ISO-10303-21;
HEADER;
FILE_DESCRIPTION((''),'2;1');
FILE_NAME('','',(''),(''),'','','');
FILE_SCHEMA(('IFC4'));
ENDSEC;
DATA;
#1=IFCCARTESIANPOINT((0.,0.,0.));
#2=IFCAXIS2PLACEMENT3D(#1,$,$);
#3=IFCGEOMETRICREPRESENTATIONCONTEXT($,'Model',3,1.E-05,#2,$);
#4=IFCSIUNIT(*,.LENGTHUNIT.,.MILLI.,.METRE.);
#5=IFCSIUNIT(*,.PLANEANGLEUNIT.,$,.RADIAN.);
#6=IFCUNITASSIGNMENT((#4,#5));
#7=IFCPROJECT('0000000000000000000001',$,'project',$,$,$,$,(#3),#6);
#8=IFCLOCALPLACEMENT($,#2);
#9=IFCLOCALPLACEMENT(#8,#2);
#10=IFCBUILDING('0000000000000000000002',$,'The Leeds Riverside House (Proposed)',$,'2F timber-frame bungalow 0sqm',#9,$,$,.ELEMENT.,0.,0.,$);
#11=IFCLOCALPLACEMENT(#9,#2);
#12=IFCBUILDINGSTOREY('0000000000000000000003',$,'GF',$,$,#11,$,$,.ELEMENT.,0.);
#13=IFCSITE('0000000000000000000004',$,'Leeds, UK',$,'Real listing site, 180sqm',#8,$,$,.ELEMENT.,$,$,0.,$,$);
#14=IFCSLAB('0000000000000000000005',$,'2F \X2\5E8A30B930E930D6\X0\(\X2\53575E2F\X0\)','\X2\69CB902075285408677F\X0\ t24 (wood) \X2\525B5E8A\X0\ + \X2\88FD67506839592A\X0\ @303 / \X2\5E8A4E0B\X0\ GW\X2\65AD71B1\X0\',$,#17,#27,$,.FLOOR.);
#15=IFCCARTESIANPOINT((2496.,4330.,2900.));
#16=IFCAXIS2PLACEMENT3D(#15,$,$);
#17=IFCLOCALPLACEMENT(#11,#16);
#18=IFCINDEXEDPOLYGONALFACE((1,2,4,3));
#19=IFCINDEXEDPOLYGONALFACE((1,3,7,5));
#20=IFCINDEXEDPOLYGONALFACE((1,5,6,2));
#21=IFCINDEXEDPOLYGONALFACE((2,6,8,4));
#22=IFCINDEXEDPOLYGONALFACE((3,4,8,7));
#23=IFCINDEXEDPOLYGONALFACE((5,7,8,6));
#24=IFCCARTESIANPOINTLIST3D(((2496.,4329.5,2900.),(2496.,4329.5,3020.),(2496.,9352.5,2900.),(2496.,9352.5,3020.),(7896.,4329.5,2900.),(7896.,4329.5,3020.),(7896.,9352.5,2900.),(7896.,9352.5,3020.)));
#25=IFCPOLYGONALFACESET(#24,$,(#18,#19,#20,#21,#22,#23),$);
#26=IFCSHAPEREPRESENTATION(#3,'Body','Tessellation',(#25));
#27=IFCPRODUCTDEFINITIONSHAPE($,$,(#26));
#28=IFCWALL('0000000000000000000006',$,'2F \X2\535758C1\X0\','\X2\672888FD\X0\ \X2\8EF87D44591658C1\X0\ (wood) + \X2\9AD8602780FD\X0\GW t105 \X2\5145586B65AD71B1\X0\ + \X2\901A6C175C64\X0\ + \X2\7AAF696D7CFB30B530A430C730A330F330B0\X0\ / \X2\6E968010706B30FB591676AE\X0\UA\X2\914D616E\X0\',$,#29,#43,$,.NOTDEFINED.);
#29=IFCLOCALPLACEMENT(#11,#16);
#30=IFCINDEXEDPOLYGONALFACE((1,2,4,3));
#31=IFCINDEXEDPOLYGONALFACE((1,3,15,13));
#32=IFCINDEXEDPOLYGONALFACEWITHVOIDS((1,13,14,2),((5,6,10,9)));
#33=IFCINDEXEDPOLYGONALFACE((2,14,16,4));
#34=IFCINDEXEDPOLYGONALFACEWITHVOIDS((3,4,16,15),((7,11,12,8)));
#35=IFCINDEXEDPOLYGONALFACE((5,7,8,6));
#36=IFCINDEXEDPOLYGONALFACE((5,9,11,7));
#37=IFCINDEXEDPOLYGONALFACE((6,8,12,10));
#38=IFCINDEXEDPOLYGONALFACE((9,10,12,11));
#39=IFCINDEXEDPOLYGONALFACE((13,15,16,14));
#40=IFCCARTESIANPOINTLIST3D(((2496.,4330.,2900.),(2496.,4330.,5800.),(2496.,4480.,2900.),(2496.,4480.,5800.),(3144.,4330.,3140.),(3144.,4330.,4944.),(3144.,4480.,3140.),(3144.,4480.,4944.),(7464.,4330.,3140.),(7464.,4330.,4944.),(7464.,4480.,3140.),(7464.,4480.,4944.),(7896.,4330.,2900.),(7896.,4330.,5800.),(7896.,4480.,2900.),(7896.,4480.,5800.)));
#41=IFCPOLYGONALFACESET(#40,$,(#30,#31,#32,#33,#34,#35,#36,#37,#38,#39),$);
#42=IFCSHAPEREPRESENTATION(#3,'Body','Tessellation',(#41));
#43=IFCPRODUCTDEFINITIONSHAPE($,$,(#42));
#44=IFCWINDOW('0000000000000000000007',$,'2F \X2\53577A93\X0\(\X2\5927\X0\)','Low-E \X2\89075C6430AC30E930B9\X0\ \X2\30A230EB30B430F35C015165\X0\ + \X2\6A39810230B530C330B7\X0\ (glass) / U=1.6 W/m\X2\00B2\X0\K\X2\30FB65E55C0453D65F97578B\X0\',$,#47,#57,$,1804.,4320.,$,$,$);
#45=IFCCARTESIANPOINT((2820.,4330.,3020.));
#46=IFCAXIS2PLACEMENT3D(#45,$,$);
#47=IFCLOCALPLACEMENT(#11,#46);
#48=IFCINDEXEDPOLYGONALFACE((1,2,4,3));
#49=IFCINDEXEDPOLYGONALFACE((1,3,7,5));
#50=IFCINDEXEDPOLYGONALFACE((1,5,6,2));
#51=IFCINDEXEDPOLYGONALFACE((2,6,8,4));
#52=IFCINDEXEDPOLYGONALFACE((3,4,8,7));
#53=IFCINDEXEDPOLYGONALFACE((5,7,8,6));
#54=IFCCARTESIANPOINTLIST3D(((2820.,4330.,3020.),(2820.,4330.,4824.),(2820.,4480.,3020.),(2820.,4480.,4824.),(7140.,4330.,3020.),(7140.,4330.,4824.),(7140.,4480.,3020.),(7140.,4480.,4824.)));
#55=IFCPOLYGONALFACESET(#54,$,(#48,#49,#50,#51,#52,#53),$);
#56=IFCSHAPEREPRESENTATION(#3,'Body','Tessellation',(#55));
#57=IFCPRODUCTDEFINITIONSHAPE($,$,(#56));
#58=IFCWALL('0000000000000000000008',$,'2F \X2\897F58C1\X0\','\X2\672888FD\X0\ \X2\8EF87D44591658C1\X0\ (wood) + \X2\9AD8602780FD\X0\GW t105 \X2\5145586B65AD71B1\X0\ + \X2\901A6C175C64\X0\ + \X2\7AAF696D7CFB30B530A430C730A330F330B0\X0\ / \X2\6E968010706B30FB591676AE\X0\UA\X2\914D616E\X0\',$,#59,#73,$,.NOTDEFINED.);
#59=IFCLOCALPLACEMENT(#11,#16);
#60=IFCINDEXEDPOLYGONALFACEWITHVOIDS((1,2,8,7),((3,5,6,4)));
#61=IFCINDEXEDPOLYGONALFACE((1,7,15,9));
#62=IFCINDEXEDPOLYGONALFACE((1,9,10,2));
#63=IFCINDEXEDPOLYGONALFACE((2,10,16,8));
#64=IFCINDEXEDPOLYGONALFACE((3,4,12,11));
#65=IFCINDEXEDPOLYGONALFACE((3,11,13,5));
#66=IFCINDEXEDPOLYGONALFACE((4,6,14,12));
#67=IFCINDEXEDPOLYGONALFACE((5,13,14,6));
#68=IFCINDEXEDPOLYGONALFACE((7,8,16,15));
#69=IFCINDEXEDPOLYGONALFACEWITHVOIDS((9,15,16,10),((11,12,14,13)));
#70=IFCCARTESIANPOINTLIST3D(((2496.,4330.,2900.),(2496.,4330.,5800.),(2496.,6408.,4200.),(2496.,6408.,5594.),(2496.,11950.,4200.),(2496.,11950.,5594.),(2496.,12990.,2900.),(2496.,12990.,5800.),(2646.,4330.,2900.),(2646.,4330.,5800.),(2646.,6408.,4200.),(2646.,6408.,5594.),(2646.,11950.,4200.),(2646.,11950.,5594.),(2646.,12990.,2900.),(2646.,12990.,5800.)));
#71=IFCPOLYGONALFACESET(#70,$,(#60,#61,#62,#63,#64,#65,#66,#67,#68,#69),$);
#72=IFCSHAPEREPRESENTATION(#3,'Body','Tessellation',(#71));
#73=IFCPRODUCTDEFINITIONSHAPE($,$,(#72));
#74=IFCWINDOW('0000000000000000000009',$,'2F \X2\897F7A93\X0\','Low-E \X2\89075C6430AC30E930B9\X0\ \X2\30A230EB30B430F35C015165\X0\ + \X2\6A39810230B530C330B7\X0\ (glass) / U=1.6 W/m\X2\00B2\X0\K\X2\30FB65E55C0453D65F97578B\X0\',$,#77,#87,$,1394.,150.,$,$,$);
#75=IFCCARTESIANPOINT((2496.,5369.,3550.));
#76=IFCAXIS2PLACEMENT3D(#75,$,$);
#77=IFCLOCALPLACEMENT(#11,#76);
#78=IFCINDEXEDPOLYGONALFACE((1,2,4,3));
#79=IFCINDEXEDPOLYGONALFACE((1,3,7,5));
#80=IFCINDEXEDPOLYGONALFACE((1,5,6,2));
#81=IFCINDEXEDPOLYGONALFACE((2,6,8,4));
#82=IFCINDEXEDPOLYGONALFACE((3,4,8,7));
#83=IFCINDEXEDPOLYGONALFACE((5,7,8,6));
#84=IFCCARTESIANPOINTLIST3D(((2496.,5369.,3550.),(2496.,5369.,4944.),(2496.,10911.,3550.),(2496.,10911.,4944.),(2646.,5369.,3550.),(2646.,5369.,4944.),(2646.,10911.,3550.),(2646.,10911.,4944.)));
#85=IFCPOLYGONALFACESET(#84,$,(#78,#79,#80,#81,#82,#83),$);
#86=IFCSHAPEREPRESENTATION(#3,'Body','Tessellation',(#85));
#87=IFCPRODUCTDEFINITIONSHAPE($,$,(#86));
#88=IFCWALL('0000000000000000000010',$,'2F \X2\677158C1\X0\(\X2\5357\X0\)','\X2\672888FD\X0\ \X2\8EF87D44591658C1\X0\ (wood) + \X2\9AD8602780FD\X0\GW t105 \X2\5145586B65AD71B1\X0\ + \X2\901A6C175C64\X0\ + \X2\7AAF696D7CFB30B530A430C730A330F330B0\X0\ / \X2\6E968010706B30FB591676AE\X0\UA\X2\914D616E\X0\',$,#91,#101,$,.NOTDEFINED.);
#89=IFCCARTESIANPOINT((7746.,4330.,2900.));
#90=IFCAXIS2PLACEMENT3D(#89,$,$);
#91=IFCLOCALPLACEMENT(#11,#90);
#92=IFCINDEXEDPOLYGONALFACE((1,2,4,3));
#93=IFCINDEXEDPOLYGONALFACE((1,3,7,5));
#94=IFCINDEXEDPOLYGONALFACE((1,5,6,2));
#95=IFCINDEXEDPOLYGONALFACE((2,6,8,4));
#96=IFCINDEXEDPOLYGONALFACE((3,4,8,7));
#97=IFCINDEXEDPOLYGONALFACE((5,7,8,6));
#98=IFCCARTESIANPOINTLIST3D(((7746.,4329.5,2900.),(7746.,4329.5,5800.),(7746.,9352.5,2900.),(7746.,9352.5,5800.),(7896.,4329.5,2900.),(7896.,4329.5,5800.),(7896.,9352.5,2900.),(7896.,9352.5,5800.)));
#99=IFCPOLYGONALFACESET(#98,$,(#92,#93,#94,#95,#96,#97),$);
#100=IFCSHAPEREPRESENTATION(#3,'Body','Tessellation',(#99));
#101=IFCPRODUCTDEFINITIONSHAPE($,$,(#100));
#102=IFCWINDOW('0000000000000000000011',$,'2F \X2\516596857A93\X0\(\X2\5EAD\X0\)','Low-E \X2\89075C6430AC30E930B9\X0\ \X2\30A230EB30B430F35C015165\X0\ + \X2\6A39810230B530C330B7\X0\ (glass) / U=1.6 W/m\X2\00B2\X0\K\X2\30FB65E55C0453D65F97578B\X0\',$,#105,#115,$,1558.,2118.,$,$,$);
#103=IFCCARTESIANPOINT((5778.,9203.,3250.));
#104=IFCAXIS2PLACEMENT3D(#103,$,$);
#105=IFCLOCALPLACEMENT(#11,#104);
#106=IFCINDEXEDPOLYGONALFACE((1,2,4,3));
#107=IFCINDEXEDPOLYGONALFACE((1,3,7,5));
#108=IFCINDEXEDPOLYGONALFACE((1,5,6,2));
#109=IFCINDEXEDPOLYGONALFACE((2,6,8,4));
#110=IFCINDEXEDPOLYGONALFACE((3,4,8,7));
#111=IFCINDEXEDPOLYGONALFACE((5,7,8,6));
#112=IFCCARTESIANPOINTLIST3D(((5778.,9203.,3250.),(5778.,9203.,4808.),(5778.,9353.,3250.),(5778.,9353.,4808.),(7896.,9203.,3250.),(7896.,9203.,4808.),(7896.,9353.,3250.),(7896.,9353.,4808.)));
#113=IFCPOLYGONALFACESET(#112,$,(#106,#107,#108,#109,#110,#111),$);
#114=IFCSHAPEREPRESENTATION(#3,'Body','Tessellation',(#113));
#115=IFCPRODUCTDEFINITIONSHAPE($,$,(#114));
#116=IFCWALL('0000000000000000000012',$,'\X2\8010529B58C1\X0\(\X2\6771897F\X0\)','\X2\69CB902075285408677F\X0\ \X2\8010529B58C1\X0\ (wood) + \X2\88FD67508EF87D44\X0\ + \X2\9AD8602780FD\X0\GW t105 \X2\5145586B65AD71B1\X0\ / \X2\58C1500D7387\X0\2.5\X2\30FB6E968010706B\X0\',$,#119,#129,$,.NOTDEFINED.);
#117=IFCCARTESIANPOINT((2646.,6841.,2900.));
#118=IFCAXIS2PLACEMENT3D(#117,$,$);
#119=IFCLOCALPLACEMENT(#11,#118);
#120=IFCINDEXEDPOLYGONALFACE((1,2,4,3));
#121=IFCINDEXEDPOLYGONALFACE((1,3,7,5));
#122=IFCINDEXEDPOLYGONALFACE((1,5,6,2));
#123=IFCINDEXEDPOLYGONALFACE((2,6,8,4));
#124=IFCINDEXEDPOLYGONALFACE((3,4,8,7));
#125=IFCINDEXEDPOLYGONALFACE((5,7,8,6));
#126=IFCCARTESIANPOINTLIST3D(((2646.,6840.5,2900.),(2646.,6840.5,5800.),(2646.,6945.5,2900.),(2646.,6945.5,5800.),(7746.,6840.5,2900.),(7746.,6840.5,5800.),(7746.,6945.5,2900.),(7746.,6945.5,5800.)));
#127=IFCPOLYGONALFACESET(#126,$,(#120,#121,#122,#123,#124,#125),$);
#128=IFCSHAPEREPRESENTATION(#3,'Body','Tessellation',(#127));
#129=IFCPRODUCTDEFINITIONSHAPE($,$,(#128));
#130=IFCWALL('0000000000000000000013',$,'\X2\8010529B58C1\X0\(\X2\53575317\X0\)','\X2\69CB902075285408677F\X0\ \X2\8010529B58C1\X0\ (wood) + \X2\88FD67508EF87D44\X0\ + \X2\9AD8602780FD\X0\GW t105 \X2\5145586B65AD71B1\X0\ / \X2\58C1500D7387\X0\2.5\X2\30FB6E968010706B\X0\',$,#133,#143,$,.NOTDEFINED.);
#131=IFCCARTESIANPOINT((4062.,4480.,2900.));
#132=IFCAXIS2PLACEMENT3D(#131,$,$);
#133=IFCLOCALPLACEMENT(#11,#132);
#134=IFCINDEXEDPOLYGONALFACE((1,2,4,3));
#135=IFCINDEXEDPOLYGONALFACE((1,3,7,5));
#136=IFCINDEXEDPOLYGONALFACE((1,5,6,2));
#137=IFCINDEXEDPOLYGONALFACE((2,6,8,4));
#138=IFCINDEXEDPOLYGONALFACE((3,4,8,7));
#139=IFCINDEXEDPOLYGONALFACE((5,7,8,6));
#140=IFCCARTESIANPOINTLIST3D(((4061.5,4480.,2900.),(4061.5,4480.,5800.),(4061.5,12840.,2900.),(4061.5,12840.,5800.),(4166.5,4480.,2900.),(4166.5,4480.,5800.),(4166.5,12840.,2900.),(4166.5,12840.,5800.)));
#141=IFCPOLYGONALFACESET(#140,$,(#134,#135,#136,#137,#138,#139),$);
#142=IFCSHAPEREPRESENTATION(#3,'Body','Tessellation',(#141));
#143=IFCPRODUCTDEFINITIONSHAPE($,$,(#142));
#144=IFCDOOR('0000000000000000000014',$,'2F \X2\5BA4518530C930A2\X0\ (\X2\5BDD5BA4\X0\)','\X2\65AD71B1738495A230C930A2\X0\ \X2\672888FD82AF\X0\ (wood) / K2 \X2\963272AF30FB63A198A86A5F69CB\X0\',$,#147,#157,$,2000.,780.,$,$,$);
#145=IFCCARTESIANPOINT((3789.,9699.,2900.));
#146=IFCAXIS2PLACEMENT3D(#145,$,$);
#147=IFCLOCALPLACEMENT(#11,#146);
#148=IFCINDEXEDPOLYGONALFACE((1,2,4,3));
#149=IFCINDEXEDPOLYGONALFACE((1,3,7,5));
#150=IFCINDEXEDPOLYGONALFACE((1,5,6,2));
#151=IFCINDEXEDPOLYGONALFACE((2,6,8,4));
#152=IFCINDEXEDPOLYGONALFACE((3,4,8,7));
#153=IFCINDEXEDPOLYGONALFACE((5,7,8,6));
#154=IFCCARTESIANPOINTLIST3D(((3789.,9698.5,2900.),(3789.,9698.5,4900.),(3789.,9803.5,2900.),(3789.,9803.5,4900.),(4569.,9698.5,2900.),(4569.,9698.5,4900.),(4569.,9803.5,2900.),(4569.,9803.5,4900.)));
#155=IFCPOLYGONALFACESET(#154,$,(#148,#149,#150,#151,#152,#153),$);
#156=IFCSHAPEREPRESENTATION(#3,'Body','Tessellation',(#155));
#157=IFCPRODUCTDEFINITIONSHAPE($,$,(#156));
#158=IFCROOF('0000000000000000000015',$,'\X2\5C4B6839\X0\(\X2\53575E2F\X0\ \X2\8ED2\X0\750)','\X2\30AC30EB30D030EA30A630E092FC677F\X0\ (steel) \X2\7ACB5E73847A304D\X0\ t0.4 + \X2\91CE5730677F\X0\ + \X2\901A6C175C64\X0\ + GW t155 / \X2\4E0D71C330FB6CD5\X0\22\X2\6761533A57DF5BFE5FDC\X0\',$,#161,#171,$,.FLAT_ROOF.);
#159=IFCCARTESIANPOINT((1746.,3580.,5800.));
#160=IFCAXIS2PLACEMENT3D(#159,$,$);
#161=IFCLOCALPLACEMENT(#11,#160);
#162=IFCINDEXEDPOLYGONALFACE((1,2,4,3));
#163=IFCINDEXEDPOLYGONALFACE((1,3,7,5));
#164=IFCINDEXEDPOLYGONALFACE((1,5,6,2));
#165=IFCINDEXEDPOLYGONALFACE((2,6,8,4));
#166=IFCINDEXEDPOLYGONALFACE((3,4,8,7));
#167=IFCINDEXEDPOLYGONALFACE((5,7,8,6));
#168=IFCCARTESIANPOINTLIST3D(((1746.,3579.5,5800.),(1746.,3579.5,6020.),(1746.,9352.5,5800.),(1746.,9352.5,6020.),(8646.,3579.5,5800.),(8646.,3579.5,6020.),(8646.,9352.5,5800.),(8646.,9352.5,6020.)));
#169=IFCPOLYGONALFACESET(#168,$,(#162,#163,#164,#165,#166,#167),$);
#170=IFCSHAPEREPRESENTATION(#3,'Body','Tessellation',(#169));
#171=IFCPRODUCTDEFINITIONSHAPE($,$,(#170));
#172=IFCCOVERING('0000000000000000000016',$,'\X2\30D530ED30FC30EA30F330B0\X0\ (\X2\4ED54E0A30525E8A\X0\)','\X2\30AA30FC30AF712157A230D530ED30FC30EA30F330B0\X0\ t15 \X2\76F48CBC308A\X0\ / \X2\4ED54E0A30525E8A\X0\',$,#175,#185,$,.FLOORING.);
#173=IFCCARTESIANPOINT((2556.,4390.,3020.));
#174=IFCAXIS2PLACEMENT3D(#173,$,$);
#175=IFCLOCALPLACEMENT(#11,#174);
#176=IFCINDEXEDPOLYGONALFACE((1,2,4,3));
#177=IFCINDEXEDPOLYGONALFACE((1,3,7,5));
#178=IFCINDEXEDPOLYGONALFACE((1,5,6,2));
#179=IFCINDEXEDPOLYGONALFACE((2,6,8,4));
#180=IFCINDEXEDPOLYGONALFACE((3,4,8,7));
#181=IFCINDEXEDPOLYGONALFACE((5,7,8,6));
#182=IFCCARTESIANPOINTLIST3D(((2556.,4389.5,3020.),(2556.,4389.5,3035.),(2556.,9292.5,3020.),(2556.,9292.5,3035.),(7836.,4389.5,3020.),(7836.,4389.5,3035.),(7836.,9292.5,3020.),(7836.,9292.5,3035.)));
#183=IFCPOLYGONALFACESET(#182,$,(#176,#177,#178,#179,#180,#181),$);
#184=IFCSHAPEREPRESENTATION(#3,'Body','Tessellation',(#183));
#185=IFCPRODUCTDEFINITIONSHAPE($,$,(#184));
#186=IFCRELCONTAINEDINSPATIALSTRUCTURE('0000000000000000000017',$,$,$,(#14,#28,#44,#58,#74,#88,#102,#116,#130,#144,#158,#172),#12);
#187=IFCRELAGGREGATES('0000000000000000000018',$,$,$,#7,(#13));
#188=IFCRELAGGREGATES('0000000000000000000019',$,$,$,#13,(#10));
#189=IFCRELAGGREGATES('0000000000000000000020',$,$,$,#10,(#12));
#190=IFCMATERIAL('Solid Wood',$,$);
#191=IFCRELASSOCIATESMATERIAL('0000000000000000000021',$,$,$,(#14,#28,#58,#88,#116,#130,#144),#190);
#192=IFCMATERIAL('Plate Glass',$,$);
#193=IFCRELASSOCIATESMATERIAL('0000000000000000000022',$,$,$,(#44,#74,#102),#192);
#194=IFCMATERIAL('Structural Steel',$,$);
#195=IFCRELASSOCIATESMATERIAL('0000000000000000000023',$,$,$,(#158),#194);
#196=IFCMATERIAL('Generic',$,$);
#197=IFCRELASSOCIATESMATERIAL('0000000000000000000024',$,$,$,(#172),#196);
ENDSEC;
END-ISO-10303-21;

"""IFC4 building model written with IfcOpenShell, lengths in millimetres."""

from ifc_helpers import new_model, si_unit, frame, frame_2d, origin, place, context, project, spatial, rectangle, extrude, material, element, fill, save


model = new_model("IFC4")

# Units and contexts
model_context = context("Model", 3, precision=1e-05, world=origin())
ifc_project = project(units=[si_unit("LENGTHUNIT", "METRE", prefix="MILLI"), si_unit("PLANEANGLEUNIT", "RADIAN")], contexts=[model_context])

# Site, building, storey
site_placement = place(None, origin())
site = spatial("IfcSite", under=ifc_project, at=site_placement, Name="Leeds, UK", ObjectType="Real listing site, 180sqm", CompositionType="ELEMENT", RefElevation=0.0)
building_placement = place(site_placement, origin())
building = spatial("IfcBuilding", under=site, at=building_placement, Name="The Leeds Riverside House (Proposed)", ObjectType="2F timber-frame bungalow 0sqm", CompositionType="ELEMENT", ElevationOfRefHeight=0.0, ElevationOfTerrain=0.0)
storey_placement = place(building_placement, origin())
storey = spatial("IfcBuildingStorey", under=building, at=storey_placement, Name="GF", CompositionType="ELEMENT", Elevation=0.0)

# Slab
ifc_material_1 = material(Name="Solid Wood")
slab_placement = place(storey_placement, frame((2496.0, 4330.0, 2900.0)))
element("IfcSlab", 1, at=slab_placement, inside=storey, material=ifc_material_1, Name="2F 床スラブ(南帯)", Description="構造用合板 t24 (wood) 剛床 + 製材根太 @303 / 床下 GW断熱", PredefinedType="FLOOR", context=model_context, shape_type="SweptSolid", body=[
    extrude(rectangle(XDim=5400.0, YDim=5023.0, at=frame_2d((2700.0, 2511.0))), frame((2496.0, 4330.0, 2900.0)), (0.0, 0.0, 1.0), 120.0),
])

# Walls, openings, windows
wall_1_placement = place(storey_placement, frame((2496.0, 4330.0, 2900.0)))
wall_1 = element("IfcWall", 2, at=wall_1_placement, inside=storey, material=ifc_material_1, Name="2F 南壁", Description="木製 軸組外壁 (wood) + 高性能GW t105 充填断熱 + 通気層 + 窯業系サイディング / 準耐火・外皮UA配慮", PredefinedType="NOTDEFINED", context=model_context, shape_type="SweptSolid", body=[
    extrude(rectangle(XDim=5400.0, YDim=150.0, at=frame_2d((2700.0, 75.0))), frame((2496.0, 4330.0, 2900.0)), (0.0, 0.0, 1.0), 2900.0),
])
opening_1_placement = place(storey_placement, frame((2820.0, 4330.0, 3020.0)))
opening_1 = element("IfcOpeningElement", 3, at=opening_1_placement, cuts=wall_1, PredefinedType="NOTDEFINED", context=model_context, shape_type="SweptSolid", body=[
    extrude(rectangle(XDim=4320.0, YDim=150.0, at=frame_2d((2160.0, 75.0))), frame((2820.0, 4330.0, 3020.0)), (0.0, 0.0, 1.0), 1804.0),
])
ifc_material_2 = material(Name="Plate Glass")
window_1_placement = place(storey_placement, frame((2820.0, 4330.0, 3020.0)))
window_1 = element("IfcWindow", 4, at=window_1_placement, inside=storey, material=ifc_material_2, Name="2F 南窓(大)", Description="Low-E 複層ガラス アルゴン封入 + 樹脂サッシ (glass) / U=1.6 W/m²K・日射取得型", OverallHeight=1804.0, OverallWidth=4320.0, context=model_context, shape_type="SweptSolid", body=[
    extrude(rectangle(XDim=4320.0, YDim=150.0, at=frame_2d((2160.0, 75.0))), frame((2820.0, 4330.0, 3020.0)), (0.0, 0.0, 1.0), 1804.0),
])
fill(opening_1, window_1)
wall_2_placement = place(storey_placement, frame((2496.0, 4330.0, 2900.0)))
wall_2 = element("IfcWall", 5, at=wall_2_placement, inside=storey, material=ifc_material_1, Name="2F 西壁", Description="木製 軸組外壁 (wood) + 高性能GW t105 充填断熱 + 通気層 + 窯業系サイディング / 準耐火・外皮UA配慮", PredefinedType="NOTDEFINED", context=model_context, shape_type="SweptSolid", body=[
    extrude(rectangle(XDim=150.0, YDim=8660.0, at=frame_2d((75.0, 4330.0))), frame((2496.0, 4330.0, 2900.0)), (0.0, 0.0, 1.0), 2900.0),
])
opening_2_placement = place(storey_placement, frame((2496.0, 5369.0, 3550.0)))
opening_2 = element("IfcOpeningElement", 6, at=opening_2_placement, cuts=wall_2, PredefinedType="NOTDEFINED", context=model_context, shape_type="SweptSolid", body=[
    extrude(rectangle(XDim=150.0, YDim=5542.0, at=frame_2d((75.0, 2771.0))), frame((2496.0, 5369.0, 3550.0)), (0.0, 0.0, 1.0), 1394.0),
])
window_2_placement = place(storey_placement, frame((2496.0, 5369.0, 3550.0)))
window_2 = element("IfcWindow", 7, at=window_2_placement, inside=storey, material=ifc_material_2, Name="2F 西窓", Description="Low-E 複層ガラス アルゴン封入 + 樹脂サッシ (glass) / U=1.6 W/m²K・日射取得型", OverallHeight=1394.0, OverallWidth=150.0, context=model_context, shape_type="SweptSolid", body=[
    extrude(rectangle(XDim=150.0, YDim=5542.0, at=frame_2d((75.0, 2771.0))), frame((2496.0, 5369.0, 3550.0)), (0.0, 0.0, 1.0), 1394.0),
])
fill(opening_2, window_2)
wall_3_placement = place(storey_placement, frame((7746.0, 4330.0, 2900.0)))
wall_3 = element("IfcWall", 8, at=wall_3_placement, inside=storey, material=ifc_material_1, Name="2F 東壁(南)", Description="木製 軸組外壁 (wood) + 高性能GW t105 充填断熱 + 通気層 + 窯業系サイディング / 準耐火・外皮UA配慮", PredefinedType="NOTDEFINED", context=model_context, shape_type="SweptSolid", body=[
    extrude(rectangle(XDim=150.0, YDim=5023.0, at=frame_2d((75.0, 2511.0))), frame((7746.0, 4330.0, 2900.0)), (0.0, 0.0, 1.0), 2900.0),
])
opening_3_placement = place(storey_placement, frame((5778.0, 9203.0, 3250.0)))
opening_3 = element("IfcOpeningElement", 9, at=opening_3_placement, cuts=wall_3, PredefinedType="NOTDEFINED", context=model_context, shape_type="SweptSolid", body=[
    extrude(rectangle(XDim=2118.0, YDim=150.0, at=frame_2d((1059.0, 75.0))), frame((5778.0, 9203.0, 3250.0)), (0.0, 0.0, 1.0), 1558.0),
])
window_3_placement = place(storey_placement, frame((5778.0, 9203.0, 3250.0)))
window_3 = element("IfcWindow", 10, at=window_3_placement, inside=storey, material=ifc_material_2, Name="2F 入隅窓(庭)", Description="Low-E 複層ガラス アルゴン封入 + 樹脂サッシ (glass) / U=1.6 W/m²K・日射取得型", OverallHeight=1558.0, OverallWidth=2118.0, context=model_context, shape_type="SweptSolid", body=[
    extrude(rectangle(XDim=2118.0, YDim=150.0, at=frame_2d((1059.0, 75.0))), frame((5778.0, 9203.0, 3250.0)), (0.0, 0.0, 1.0), 1558.0),
])
fill(opening_3, window_3)

# Wall
wall_4_placement = place(storey_placement, frame((2646.0, 6841.0, 2900.0)))
element("IfcWall", 11, at=wall_4_placement, inside=storey, material=ifc_material_1, Name="耐力壁(東西)", Description="構造用合板 耐力壁 (wood) + 製材軸組 + 高性能GW t105 充填断熱 / 壁倍率2.5・準耐火", PredefinedType="NOTDEFINED", context=model_context, shape_type="SweptSolid", body=[
    extrude(rectangle(XDim=5100.0, YDim=105.0, at=frame_2d((2550.0, 52.0))), frame((2646.0, 6841.0, 2900.0)), (0.0, 0.0, 1.0), 2900.0),
])

# Wall, opening, door
wall_5_placement = place(storey_placement, frame((4062.0, 4480.0, 2900.0)))
wall_5 = element("IfcWall", 12, at=wall_5_placement, inside=storey, material=ifc_material_1, Name="耐力壁(南北)", Description="構造用合板 耐力壁 (wood) + 製材軸組 + 高性能GW t105 充填断熱 / 壁倍率2.5・準耐火", PredefinedType="NOTDEFINED", context=model_context, shape_type="SweptSolid", body=[
    extrude(rectangle(XDim=105.0, YDim=8360.0, at=frame_2d((52.0, 4180.0))), frame((4062.0, 4480.0, 2900.0)), (0.0, 0.0, 1.0), 2900.0),
])
opening_4_placement = place(storey_placement, frame((3789.0, 9699.0, 2900.0)))
opening_4 = element("IfcOpeningElement", 13, at=opening_4_placement, cuts=wall_5, PredefinedType="NOTDEFINED", context=model_context, shape_type="SweptSolid", body=[
    extrude(rectangle(XDim=780.0, YDim=105.0, at=frame_2d((390.0, 52.0))), frame((3789.0, 9699.0, 2900.0)), (0.0, 0.0, 1.0), 2000.0),
])
door_placement = place(storey_placement, frame((3789.0, 9699.0, 2900.0)))
door = element("IfcDoor", 14, at=door_placement, inside=storey, material=ifc_material_1, Name="2F 室内ドア (寝室)", Description="断熱玄関ドア 木製芯 (wood) / K2 防犯・採風機構", OverallHeight=2000.0, OverallWidth=780.0, context=model_context, shape_type="SweptSolid", body=[
    extrude(rectangle(XDim=780.0, YDim=105.0, at=frame_2d((390.0, 52.0))), frame((3789.0, 9699.0, 2900.0)), (0.0, 0.0, 1.0), 2000.0),
])
fill(opening_4, door)

# Roof
ifc_material_3 = material(Name="Structural Steel")
for number, where, name in (
    (15, (1746.0, 3580.0, 5800.0), "屋根(南帯 軒750)"),
):
    element("IfcRoof", number, at=place(storey_placement, frame(where)), inside=storey, material=ifc_material_3, Name=name, Description="ガルバリウム鋼板 (steel) 立平葺き t0.4 + 野地板 + 通気層 + GW t155 / 不燃・法22条区域対応", PredefinedType="FLAT_ROOF", context=model_context, shape_type="SweptSolid", body=[
        extrude(rectangle(XDim=6900.0, YDim=5773.0, at=frame_2d((3450.0, 2886.0))), frame((1746.0, 3580.0, 5800.0)), (0.0, 0.0, 1.0), 220.0),
    ])

# Covering
ifc_material_4 = material(Name="Generic")
covering_placement = place(storey_placement, frame((2556.0, 4390.0, 3020.0)))
element("IfcCovering", 16, at=covering_placement, inside=storey, material=ifc_material_4, Name="フローリング (仕上げ床)", Description="オーク無垢フローリング t15 直貼り / 仕上げ床", PredefinedType="FLOORING", context=model_context, shape_type="SweptSolid", body=[
    extrude(rectangle(XDim=5280.0, YDim=4903.0, at=frame_2d((2640.0, 2451.0))), frame((2556.0, 4390.0, 3020.0)), (0.0, 0.0, 1.0), 15.0),
])

save(model, "model.ifc")
